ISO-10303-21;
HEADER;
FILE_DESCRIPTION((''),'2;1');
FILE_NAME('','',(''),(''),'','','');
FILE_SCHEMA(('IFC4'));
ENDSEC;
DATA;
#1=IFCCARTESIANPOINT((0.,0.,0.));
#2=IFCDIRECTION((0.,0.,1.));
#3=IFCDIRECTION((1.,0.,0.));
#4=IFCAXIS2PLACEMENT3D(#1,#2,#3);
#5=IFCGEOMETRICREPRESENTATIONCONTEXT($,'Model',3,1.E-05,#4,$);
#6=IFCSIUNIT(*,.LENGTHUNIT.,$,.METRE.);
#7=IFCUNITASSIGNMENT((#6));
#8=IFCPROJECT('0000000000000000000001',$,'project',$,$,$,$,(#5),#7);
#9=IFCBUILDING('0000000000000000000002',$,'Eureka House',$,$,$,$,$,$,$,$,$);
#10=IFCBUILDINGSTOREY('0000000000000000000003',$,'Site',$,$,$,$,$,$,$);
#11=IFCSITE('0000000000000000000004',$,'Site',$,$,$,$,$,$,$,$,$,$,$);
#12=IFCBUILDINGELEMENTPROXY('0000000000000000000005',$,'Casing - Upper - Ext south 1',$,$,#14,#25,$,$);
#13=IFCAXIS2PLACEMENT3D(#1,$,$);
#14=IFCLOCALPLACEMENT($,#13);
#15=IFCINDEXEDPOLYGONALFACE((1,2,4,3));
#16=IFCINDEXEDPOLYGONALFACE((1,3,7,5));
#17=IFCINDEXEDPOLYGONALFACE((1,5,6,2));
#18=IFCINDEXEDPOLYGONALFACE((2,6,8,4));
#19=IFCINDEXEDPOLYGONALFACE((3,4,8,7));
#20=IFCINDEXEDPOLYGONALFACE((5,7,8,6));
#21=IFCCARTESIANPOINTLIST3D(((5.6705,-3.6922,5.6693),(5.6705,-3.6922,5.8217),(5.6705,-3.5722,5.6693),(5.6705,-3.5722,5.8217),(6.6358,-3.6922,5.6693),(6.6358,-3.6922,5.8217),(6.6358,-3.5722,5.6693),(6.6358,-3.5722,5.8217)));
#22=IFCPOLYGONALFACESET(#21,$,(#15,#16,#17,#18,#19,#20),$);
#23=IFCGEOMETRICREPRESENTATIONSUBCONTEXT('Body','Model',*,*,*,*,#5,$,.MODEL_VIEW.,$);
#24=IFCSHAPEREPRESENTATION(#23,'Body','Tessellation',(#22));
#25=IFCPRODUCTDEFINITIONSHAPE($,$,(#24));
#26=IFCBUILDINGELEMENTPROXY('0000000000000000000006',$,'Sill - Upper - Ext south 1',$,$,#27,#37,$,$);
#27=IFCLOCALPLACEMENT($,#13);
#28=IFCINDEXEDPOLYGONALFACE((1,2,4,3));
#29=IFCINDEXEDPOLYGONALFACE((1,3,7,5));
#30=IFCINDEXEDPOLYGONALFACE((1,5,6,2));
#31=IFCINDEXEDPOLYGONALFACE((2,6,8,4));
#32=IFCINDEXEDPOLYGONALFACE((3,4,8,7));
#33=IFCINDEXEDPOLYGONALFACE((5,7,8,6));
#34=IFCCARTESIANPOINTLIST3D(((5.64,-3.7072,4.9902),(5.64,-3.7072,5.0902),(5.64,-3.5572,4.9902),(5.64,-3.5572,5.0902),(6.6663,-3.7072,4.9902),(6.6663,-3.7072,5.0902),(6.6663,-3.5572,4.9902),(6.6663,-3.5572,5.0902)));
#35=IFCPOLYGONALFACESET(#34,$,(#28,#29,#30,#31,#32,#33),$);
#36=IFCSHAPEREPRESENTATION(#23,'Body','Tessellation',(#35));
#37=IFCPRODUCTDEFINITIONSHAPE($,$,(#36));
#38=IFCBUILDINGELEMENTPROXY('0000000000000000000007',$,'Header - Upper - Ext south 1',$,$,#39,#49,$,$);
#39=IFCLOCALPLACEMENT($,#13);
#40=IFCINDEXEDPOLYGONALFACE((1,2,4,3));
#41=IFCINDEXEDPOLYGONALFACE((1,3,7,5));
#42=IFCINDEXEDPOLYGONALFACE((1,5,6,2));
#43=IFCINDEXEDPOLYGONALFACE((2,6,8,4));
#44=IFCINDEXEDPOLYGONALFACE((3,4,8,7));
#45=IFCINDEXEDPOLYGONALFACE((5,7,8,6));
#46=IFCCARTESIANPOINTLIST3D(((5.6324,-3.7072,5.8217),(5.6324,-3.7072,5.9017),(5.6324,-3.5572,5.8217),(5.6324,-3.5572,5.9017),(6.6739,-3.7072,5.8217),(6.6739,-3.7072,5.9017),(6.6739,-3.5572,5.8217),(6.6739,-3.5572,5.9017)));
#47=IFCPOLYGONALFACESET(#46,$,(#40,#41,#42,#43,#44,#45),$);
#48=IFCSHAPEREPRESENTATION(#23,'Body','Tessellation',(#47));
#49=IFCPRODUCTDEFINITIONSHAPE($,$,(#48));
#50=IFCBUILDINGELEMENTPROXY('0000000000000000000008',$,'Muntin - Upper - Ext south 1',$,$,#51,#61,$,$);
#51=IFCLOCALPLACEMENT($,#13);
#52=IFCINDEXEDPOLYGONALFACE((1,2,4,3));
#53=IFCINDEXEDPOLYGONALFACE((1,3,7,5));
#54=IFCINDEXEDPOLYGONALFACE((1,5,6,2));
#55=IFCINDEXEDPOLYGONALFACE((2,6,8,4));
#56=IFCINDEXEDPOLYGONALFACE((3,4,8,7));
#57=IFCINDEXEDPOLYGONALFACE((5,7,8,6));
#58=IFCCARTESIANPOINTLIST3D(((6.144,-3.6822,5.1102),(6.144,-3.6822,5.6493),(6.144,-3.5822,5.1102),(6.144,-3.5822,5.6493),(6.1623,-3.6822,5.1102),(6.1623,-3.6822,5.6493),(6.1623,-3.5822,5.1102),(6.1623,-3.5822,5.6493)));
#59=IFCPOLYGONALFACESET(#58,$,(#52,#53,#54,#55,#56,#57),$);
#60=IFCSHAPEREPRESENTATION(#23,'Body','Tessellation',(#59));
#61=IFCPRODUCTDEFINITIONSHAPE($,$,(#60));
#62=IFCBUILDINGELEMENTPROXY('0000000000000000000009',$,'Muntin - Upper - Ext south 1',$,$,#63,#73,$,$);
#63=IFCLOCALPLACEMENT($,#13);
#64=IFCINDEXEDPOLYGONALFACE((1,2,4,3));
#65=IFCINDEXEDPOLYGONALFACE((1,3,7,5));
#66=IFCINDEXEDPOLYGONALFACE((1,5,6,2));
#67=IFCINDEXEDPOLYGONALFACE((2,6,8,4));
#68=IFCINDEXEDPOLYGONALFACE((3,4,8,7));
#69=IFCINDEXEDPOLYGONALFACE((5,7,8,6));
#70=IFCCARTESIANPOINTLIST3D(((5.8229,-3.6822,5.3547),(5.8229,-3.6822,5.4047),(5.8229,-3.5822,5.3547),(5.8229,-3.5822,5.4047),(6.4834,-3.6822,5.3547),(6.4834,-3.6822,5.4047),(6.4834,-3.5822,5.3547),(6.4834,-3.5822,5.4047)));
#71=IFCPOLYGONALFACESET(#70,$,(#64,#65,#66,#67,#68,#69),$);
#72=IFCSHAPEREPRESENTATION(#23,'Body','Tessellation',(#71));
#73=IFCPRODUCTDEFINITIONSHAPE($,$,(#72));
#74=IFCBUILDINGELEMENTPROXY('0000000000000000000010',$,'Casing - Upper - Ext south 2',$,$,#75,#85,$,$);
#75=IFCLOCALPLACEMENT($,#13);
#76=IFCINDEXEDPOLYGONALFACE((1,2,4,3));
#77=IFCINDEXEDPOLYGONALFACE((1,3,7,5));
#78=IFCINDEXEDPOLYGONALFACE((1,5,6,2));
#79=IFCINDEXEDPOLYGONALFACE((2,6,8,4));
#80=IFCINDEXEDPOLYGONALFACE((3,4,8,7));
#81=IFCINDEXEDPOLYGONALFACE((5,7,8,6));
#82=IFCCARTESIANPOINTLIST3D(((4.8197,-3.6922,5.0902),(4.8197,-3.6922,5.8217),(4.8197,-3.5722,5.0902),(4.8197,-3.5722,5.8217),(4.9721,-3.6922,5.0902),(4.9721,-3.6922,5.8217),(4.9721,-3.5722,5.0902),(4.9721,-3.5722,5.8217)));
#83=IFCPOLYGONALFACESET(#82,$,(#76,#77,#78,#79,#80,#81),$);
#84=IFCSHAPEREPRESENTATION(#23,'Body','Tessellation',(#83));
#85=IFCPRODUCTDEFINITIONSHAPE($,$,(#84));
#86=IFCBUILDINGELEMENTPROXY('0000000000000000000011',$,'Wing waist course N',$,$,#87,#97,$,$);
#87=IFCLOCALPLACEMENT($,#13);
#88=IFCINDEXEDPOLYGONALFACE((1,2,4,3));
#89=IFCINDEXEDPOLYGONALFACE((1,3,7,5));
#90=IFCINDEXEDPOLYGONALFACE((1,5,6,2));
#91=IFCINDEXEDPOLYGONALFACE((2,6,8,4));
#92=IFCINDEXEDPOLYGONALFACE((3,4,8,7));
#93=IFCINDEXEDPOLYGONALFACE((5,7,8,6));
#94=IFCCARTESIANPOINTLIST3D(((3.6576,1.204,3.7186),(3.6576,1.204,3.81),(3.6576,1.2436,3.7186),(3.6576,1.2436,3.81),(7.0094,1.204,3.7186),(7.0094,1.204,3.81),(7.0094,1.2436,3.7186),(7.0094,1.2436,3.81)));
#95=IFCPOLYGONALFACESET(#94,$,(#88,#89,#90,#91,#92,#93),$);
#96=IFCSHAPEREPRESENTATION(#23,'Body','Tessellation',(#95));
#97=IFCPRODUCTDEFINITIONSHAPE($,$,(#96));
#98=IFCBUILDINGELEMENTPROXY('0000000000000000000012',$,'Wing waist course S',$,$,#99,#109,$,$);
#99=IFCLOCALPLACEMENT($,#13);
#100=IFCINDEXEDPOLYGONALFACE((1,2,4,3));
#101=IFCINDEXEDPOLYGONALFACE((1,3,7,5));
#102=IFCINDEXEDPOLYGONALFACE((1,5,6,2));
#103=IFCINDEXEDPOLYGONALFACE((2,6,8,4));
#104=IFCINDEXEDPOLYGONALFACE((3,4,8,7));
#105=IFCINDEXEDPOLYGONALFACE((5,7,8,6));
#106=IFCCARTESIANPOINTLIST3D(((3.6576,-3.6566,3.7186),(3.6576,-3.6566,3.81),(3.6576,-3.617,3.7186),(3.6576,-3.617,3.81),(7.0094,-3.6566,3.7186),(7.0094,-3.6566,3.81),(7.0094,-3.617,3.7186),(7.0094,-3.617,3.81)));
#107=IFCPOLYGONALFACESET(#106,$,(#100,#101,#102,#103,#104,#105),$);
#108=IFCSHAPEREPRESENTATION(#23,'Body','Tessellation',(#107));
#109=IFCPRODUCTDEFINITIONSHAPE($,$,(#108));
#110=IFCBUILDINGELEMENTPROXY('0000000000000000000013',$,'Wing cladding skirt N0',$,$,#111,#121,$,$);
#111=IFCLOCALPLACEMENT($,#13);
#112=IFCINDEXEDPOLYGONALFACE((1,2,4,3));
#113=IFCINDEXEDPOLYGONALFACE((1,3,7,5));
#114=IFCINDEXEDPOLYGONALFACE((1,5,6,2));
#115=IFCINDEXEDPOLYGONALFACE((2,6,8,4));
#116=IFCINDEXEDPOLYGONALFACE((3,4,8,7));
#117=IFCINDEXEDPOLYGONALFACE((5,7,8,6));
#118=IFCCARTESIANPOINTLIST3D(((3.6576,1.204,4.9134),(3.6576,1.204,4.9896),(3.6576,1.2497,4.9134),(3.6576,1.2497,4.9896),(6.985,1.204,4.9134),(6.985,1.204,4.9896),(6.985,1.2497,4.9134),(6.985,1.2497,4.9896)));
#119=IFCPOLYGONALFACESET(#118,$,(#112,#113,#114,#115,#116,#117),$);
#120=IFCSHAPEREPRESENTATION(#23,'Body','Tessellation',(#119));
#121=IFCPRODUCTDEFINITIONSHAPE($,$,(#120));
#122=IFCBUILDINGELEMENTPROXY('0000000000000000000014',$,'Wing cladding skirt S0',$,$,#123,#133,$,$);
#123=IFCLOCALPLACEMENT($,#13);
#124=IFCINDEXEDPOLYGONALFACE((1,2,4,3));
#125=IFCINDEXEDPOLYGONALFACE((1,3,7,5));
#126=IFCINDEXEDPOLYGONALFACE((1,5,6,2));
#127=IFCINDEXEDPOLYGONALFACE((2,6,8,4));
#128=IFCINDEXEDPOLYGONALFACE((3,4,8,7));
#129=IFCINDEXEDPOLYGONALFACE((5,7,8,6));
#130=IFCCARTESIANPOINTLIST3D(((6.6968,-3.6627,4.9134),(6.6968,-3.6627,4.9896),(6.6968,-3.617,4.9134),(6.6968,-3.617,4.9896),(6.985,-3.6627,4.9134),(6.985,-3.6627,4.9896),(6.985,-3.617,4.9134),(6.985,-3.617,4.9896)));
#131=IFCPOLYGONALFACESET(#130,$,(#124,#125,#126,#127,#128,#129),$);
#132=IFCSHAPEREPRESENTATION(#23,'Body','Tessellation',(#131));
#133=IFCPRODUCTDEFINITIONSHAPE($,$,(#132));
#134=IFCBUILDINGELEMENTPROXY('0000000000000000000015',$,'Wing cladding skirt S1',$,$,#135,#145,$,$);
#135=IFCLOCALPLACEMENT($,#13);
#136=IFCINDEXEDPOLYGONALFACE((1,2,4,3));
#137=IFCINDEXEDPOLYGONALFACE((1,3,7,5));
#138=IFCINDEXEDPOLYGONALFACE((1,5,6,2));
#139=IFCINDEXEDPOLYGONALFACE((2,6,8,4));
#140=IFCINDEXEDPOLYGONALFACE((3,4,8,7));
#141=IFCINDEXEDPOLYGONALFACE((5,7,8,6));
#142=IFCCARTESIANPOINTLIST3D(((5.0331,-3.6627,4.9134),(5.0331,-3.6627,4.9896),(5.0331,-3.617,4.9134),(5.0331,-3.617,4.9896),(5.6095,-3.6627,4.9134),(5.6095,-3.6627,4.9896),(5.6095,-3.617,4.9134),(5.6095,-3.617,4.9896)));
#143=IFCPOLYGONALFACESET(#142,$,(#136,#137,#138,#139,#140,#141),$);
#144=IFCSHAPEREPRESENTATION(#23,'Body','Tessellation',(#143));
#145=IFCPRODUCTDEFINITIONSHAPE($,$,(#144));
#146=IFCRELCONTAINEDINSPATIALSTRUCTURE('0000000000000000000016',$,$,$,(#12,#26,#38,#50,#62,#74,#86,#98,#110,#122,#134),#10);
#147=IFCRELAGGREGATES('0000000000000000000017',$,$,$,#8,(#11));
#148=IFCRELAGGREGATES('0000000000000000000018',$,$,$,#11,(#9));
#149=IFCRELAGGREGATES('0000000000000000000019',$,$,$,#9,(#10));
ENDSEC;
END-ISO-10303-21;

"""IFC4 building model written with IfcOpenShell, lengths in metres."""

from ifc_helpers import new_model, si_unit, frame, origin, origin_with_axes, origin_2d, place, context, subcontext, project, spatial, rectangle, extrude, element, save


model = new_model("IFC4")

# Units and contexts
model_context = context("Model", 3, precision=1e-05, world=origin_with_axes())
body_context = subcontext(model_context, "Body", "Model", "MODEL_VIEW")
ifc_project = project(units=[si_unit("LENGTHUNIT", "METRE")], contexts=[model_context])

# Site, building, storey
site = spatial("IfcSite", under=ifc_project, Name="Site")
building = spatial("IfcBuilding", under=site, Name="Eureka House")
storey = spatial("IfcBuildingStorey", under=building, Name="Site")

# Building element proxies
proxy_1_placement = place(None, frame((6.1532, -3.6322, 5.6693), z_axis=(0.0, 0.0, 1.0), x_axis=(1.0, 0.0, 0.0)))
element("IfcBuildingElementProxy", 1, at=proxy_1_placement, inside=storey, Name="Casing - Upper - Ext south 1", context=body_context, shape_type="SweptSolid", body=[
    extrude(rectangle(XDim=0.9653, YDim=0.12, at=origin_2d()), origin(), (0.0, 0.0, 1.0), 0.1524),
])
proxy_2_placement = place(None, frame((6.1532, -3.6322, 4.9902), z_axis=(0.0, 0.0, 1.0), x_axis=(1.0, 0.0, 0.0)))
element("IfcBuildingElementProxy", 2, at=proxy_2_placement, inside=storey, Name="Sill - Upper - Ext south 1", context=body_context, shape_type="SweptSolid", body=[
    extrude(rectangle(XDim=1.0263, YDim=0.15, at=origin_2d()), origin(), (0.0, 0.0, 1.0), 0.1),
])
proxy_3_placement = place(None, frame((6.1532, -3.6322, 5.8217), z_axis=(0.0, 0.0, 1.0), x_axis=(1.0, 0.0, 0.0)))
element("IfcBuildingElementProxy", 3, at=proxy_3_placement, inside=storey, Name="Header - Upper - Ext south 1", context=body_context, shape_type="SweptSolid", body=[
    extrude(rectangle(XDim=1.0415, YDim=0.15, at=origin_2d()), origin(), (0.0, 0.0, 1.0), 0.08),
])
proxy_4_placement = place(None, frame((6.1532, -3.6322, 5.1102), z_axis=(0.0, 0.0, 1.0), x_axis=(1.0, 0.0, 0.0)))
element("IfcBuildingElementProxy", 4, at=proxy_4_placement, inside=storey, Name="Muntin - Upper - Ext south 1", context=body_context, shape_type="SweptSolid", body=[
    extrude(rectangle(XDim=0.0183, YDim=0.1, at=origin_2d()), origin(), (0.0, 0.0, 1.0), 0.5391),
])
proxy_5_placement = place(None, frame((6.1532, -3.6322, 5.3547), z_axis=(0.0, 0.0, 1.0), x_axis=(1.0, 0.0, 0.0)))
element("IfcBuildingElementProxy", 5, at=proxy_5_placement, inside=storey, Name="Muntin - Upper - Ext south 1", context=body_context, shape_type="SweptSolid", body=[
    extrude(rectangle(XDim=0.6605, YDim=0.1, at=origin_2d()), origin(), (0.0, 0.0, 1.0), 0.05),
])
proxy_6_placement = place(None, frame((4.8959, -3.6322, 5.0902), z_axis=(0.0, 0.0, 1.0), x_axis=(1.0, 0.0, 0.0)))
element("IfcBuildingElementProxy", 6, at=proxy_6_placement, inside=storey, Name="Casing - Upper - Ext south 2", context=body_context, shape_type="SweptSolid", body=[
    extrude(rectangle(XDim=0.1524, YDim=0.12, at=origin_2d()), origin(), (0.0, 0.0, 1.0), 0.7315),
])
proxy_7_placement = place(None, frame((5.3335, 1.2238, 3.7186), z_axis=(0.0, 0.0, 1.0), x_axis=(1.0, 0.0, 0.0)))
element("IfcBuildingElementProxy", 7, at=proxy_7_placement, inside=storey, Name="Wing waist course N", context=body_context, shape_type="SweptSolid", body=[
    extrude(rectangle(XDim=3.3518, YDim=0.0396, at=origin_2d()), origin(), (0.0, 0.0, 1.0), 0.0914),
])
proxy_8_placement = place(None, frame((5.3335, -3.6368, 3.7186), z_axis=(0.0, 0.0, 1.0), x_axis=(1.0, 0.0, 0.0)))
element("IfcBuildingElementProxy", 8, at=proxy_8_placement, inside=storey, Name="Wing waist course S", context=body_context, shape_type="SweptSolid", body=[
    extrude(rectangle(XDim=3.3518, YDim=0.0396, at=origin_2d()), origin(), (0.0, 0.0, 1.0), 0.0914),
])
proxy_9_placement = place(None, frame((5.3213, 1.2268, 4.9134), z_axis=(0.0, 0.0, 1.0), x_axis=(1.0, 0.0, 0.0)))
element("IfcBuildingElementProxy", 9, at=proxy_9_placement, inside=storey, Name="Wing cladding skirt N0", context=body_context, shape_type="SweptSolid", body=[
    extrude(rectangle(XDim=3.3274, YDim=0.0457, at=origin_2d()), origin(), (0.0, 0.0, 1.0), 0.0762),
])
proxy_10_placement = place(None, frame((6.8409, -3.6398, 4.9134), z_axis=(0.0, 0.0, 1.0), x_axis=(1.0, 0.0, 0.0)))
element("IfcBuildingElementProxy", 10, at=proxy_10_placement, inside=storey, Name="Wing cladding skirt S0", context=body_context, shape_type="SweptSolid", body=[
    extrude(rectangle(XDim=0.2882, YDim=0.0457, at=origin_2d()), origin(), (0.0, 0.0, 1.0), 0.0762),
])
proxy_11_placement = place(None, frame((5.3213, -3.6398, 4.9134), z_axis=(0.0, 0.0, 1.0), x_axis=(1.0, 0.0, 0.0)))
element("IfcBuildingElementProxy", 11, at=proxy_11_placement, inside=storey, Name="Wing cladding skirt S1", context=body_context, shape_type="SweptSolid", body=[
    extrude(rectangle(XDim=0.5765, YDim=0.0457, at=origin_2d()), origin(), (0.0, 0.0, 1.0), 0.0762),
])

save(model, "model.ifc")
